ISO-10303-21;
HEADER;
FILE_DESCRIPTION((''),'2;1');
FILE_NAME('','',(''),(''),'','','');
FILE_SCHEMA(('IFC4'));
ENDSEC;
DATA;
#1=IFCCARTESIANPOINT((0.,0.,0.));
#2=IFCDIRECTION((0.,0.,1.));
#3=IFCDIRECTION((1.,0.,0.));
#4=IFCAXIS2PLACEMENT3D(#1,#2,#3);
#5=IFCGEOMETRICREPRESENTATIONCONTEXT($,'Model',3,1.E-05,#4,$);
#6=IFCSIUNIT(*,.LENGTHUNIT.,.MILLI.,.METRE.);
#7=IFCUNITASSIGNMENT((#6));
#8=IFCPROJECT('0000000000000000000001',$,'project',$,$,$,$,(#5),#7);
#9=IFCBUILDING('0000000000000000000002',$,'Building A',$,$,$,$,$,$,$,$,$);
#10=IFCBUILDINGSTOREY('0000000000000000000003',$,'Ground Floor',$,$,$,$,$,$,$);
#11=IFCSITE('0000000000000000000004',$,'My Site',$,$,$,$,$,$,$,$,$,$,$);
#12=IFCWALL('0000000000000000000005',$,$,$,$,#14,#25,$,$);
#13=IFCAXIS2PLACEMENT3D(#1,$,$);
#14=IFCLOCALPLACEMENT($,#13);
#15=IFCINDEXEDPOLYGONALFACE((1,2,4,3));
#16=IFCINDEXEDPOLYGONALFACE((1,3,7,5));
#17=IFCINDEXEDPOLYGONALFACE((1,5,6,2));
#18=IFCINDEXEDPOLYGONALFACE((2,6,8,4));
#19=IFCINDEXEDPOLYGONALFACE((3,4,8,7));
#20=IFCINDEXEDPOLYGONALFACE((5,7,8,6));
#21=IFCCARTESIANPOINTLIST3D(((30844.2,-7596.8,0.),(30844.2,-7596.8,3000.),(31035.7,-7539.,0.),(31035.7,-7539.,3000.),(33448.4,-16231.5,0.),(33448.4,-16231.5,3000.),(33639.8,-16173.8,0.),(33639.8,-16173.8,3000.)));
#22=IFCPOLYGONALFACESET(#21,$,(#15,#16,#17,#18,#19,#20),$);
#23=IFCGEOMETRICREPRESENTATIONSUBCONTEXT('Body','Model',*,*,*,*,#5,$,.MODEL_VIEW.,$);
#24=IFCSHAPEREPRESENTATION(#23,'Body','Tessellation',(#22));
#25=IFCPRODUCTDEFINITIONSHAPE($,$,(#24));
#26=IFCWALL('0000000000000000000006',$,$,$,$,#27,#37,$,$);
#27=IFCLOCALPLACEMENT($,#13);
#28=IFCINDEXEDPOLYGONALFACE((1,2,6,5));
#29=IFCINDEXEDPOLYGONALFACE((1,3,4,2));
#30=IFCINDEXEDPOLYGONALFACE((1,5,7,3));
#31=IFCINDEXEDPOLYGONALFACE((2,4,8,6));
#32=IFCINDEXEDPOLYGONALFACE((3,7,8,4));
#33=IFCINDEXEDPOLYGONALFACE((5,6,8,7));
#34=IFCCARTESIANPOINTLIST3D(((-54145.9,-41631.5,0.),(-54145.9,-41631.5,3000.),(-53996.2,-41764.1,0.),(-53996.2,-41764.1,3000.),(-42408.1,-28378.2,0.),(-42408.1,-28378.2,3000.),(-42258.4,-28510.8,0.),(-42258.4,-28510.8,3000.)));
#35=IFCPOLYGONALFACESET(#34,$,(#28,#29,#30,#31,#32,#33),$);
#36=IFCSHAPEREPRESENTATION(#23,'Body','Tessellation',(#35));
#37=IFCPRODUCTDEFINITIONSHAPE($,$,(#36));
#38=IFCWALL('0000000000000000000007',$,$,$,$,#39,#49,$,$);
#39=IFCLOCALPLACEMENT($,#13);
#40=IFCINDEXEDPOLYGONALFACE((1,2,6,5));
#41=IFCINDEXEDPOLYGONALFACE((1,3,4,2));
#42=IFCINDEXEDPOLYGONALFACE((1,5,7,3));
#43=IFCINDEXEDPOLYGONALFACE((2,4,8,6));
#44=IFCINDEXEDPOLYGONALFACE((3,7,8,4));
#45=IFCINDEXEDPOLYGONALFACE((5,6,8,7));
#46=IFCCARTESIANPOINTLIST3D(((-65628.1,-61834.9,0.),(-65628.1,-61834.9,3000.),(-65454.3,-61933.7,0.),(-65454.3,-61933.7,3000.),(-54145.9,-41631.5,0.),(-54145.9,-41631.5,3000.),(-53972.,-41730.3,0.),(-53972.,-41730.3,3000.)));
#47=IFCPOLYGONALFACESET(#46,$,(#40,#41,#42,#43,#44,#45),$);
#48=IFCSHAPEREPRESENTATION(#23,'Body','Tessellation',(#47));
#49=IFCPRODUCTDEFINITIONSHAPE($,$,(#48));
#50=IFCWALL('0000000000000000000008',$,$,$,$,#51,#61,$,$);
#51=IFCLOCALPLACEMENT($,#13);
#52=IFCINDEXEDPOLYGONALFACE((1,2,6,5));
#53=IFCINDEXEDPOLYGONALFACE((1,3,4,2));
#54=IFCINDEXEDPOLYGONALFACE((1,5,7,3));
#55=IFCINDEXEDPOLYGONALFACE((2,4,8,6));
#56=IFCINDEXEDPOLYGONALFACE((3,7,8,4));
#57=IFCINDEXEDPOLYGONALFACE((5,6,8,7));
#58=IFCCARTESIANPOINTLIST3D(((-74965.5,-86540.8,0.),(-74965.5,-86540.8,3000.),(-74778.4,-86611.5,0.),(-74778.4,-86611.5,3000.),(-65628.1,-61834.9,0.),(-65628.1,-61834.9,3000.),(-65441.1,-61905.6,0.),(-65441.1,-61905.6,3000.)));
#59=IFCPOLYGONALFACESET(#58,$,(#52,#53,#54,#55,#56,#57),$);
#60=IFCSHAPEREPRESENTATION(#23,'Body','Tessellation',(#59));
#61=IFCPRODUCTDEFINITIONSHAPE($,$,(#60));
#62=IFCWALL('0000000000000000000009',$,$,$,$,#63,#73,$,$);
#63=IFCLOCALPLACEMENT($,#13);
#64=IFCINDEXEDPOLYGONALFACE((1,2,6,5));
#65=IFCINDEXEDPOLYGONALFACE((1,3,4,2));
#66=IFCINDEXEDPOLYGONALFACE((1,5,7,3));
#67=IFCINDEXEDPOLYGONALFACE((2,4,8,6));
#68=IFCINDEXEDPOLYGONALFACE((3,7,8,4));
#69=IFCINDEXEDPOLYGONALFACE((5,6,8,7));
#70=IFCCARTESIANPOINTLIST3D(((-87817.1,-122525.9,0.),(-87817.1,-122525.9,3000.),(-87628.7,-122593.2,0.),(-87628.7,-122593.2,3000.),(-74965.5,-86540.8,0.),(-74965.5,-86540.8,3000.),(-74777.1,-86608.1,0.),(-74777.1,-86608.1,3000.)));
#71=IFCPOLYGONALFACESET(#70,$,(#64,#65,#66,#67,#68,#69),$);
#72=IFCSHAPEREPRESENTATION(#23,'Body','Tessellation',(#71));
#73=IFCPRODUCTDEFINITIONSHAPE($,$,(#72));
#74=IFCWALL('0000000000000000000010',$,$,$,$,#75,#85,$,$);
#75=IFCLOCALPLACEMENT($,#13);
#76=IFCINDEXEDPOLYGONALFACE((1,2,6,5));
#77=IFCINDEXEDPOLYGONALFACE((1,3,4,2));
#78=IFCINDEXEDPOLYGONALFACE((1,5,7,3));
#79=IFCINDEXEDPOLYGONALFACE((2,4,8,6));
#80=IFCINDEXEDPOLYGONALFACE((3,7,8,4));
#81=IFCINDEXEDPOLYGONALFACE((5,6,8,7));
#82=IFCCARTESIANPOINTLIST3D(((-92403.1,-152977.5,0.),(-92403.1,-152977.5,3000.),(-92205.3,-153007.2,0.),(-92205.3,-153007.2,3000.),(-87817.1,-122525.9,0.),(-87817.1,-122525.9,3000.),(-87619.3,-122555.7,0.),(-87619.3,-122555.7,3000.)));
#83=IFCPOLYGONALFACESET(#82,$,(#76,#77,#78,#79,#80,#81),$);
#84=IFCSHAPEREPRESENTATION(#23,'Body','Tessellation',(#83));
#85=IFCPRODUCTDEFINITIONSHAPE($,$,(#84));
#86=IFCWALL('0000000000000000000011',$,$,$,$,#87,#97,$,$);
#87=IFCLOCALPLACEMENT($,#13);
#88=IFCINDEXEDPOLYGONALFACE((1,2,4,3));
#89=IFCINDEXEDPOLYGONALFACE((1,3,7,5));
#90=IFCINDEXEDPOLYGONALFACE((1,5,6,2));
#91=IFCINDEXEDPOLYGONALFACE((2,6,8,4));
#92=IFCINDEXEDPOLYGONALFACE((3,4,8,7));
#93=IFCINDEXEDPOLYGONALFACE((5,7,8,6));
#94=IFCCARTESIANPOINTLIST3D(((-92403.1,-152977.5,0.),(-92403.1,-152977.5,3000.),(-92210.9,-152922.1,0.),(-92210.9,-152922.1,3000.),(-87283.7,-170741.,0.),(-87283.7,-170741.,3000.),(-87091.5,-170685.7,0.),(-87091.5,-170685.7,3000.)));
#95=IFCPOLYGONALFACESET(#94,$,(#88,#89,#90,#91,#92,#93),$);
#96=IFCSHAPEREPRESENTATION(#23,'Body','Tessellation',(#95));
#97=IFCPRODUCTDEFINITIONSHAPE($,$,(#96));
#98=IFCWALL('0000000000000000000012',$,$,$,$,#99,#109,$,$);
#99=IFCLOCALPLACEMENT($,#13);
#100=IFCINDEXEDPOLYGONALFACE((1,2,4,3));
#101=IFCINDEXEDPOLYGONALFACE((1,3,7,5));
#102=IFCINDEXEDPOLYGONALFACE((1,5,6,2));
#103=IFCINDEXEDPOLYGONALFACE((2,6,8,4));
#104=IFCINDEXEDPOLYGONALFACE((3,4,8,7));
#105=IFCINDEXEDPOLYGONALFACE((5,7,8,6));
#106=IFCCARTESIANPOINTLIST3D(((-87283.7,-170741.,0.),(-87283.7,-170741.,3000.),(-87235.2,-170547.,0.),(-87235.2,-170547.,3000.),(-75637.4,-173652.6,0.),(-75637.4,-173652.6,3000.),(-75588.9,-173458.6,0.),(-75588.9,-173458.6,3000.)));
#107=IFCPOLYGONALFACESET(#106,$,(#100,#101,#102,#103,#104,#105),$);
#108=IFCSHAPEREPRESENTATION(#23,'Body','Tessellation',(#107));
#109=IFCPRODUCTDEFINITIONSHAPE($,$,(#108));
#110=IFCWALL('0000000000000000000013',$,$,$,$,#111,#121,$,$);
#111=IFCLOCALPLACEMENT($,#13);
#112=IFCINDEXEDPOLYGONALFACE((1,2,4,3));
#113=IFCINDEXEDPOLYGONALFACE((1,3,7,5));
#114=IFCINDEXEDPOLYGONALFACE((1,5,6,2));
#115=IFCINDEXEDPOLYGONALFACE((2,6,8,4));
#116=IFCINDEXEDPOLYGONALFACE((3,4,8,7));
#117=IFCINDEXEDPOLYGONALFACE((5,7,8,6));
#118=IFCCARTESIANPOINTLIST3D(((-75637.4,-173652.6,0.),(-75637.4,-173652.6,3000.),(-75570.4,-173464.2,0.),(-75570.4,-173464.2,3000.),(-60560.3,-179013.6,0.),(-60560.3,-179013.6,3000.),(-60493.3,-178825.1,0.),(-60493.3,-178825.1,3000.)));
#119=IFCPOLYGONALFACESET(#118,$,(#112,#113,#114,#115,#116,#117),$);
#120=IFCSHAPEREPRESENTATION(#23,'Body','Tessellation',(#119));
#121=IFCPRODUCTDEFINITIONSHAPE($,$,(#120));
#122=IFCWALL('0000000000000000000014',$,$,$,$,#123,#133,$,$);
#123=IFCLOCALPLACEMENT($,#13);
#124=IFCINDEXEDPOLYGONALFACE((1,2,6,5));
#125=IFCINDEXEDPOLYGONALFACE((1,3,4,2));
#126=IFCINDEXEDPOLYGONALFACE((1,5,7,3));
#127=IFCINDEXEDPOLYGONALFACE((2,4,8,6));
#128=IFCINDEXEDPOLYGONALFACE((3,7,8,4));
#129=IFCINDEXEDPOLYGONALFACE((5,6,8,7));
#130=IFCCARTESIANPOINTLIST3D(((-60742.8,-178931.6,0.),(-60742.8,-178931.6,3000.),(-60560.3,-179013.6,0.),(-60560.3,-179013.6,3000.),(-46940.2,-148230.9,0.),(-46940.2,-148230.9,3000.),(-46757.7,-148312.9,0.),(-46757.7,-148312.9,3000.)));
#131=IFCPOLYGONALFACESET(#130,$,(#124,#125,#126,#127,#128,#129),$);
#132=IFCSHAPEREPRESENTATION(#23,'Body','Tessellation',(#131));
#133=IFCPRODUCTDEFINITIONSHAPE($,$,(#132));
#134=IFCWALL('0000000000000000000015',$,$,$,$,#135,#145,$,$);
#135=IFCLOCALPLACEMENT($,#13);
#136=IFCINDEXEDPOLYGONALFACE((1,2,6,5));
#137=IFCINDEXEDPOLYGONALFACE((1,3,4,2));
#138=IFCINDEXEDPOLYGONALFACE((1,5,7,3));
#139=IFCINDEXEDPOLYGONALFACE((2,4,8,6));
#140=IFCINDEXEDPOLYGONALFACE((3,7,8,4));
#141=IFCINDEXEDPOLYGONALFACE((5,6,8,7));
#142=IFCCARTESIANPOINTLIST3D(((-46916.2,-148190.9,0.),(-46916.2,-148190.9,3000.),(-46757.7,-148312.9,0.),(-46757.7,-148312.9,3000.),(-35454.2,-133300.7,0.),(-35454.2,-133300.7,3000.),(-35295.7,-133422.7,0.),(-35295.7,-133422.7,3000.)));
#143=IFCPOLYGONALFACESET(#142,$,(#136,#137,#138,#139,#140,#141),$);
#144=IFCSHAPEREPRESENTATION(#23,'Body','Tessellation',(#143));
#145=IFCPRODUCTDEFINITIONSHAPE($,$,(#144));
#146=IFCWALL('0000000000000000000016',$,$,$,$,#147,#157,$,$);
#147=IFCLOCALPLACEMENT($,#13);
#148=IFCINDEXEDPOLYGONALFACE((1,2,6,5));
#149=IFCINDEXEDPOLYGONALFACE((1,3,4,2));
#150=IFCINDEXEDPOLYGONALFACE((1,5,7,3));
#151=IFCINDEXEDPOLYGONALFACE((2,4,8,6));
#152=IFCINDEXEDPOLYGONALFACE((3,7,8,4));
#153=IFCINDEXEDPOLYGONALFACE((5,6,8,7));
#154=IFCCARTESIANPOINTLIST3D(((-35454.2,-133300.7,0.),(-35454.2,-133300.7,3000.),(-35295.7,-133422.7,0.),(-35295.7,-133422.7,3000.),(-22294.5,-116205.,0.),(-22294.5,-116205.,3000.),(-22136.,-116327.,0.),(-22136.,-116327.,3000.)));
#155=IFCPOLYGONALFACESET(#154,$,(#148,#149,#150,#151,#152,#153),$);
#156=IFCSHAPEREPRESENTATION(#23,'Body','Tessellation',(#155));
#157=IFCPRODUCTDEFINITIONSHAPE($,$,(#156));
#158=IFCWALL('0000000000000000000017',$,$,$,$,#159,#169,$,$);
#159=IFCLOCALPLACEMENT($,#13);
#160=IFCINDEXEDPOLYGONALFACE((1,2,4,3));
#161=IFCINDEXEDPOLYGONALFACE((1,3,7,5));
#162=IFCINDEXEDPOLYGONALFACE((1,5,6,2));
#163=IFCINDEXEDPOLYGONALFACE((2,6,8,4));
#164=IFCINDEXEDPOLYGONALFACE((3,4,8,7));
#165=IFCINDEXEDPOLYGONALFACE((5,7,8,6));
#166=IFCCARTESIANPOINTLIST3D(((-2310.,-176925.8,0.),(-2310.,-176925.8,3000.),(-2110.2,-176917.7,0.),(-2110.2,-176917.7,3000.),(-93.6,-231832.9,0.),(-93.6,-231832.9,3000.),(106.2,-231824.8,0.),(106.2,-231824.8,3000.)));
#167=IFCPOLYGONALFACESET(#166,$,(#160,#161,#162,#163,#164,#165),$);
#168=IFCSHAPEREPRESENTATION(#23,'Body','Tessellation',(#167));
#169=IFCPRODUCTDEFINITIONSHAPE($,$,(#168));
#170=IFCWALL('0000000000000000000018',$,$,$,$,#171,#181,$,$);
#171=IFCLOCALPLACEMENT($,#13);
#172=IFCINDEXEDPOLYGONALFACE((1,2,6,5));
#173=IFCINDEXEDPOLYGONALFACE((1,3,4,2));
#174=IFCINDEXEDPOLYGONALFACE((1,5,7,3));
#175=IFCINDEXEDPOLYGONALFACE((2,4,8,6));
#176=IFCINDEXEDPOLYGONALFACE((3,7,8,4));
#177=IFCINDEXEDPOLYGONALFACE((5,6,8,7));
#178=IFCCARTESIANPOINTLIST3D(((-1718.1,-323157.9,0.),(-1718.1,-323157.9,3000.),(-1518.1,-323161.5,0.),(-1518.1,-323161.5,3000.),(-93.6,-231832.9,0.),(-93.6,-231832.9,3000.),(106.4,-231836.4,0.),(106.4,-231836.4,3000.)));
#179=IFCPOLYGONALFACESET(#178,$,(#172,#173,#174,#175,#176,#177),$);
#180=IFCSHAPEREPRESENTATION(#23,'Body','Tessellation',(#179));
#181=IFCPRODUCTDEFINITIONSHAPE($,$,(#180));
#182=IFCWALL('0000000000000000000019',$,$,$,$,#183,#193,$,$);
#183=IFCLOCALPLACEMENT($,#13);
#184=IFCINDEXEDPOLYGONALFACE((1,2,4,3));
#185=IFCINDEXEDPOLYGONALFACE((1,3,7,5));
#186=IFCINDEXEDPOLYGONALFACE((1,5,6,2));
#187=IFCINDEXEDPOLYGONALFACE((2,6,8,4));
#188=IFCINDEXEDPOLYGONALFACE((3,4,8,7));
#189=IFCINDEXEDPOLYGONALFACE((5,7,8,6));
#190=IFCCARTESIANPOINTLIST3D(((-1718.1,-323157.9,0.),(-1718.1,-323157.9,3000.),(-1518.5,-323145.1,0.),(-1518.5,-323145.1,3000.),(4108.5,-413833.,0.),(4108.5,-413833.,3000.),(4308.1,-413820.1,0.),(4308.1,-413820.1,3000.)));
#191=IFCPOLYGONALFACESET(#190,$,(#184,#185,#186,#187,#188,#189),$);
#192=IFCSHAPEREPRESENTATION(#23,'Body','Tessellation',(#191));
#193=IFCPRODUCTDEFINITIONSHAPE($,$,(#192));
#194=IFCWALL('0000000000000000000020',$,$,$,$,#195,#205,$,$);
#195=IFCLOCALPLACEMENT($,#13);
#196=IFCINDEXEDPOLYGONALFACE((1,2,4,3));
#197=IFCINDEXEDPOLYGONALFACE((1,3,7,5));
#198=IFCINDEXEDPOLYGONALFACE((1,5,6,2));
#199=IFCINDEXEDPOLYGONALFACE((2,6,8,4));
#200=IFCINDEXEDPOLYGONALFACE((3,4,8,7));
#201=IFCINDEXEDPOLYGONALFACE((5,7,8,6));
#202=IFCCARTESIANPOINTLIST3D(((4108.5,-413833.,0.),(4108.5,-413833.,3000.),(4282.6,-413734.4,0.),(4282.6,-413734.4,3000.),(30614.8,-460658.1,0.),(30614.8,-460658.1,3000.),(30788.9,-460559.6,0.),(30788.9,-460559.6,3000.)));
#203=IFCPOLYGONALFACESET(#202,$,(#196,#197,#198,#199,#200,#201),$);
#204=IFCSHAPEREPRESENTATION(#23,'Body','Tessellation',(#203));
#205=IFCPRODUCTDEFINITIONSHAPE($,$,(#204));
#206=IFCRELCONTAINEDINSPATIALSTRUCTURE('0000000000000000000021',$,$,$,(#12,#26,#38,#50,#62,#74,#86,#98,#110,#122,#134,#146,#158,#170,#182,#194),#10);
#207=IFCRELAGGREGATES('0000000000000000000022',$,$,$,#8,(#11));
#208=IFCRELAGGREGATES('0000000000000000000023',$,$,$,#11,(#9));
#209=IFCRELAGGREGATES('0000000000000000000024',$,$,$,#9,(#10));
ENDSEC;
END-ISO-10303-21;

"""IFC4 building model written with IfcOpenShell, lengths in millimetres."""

from ifc_helpers import new_model, si_unit, frame, origin_with_axes, place, context, subcontext, project, spatial, indexed_curve, outline, extrude, element, save


model = new_model("IFC4")

# Units and contexts
model_context = context("Model", 3, precision=1e-05, world=origin_with_axes())
body_context = subcontext(model_context, "Body", "Model", "MODEL_VIEW")
ifc_project = project(units=[si_unit("LENGTHUNIT", "METRE", prefix="MILLI")], contexts=[model_context])

# Site, building, storey
site = spatial("IfcSite", under=ifc_project, Name="My Site")
building = spatial("IfcBuilding", under=site, Name="Building A")
storey = spatial("IfcBuildingStorey", under=building, Name="Ground Floor")

# Walls
wall_1_placement = place(None, frame((33639.8, -16173.8, 0.0), z_axis=(0.0, 0.0, 1.0), x_axis=(-0.288745, 0.957406, 0.0)))
element("IfcWall", 1, at=wall_1_placement, inside=storey, context=body_context, shape_type="SweptSolid", body=[
    extrude(outline(indexed_curve([(0.0, 0.0), (0.0, 200.0), (9018.9, 200.0), (9018.9, 0.0), (0.0, 0.0)], self_intersect=False)), origin_with_axes(), (0.0, 0.0, 1.0), 3000.0),
])
wall_2_placement = place(None, frame((-42408.1, -28378.2, 0.0), z_axis=(0.0, 0.0, 1.0), x_axis=(-0.663009, -0.748612, 0.0)))
element("IfcWall", 2, at=wall_2_placement, inside=storey, context=body_context, shape_type="SweptSolid", body=[
    extrude(outline(indexed_curve([(0.0, 0.0), (0.0, 200.0), (17703.9, 200.0), (17703.9, 0.0), (0.0, 0.0)], self_intersect=False)), origin_with_axes(), (0.0, 0.0, 1.0), 3000.0),
])
wall_3_placement = place(None, frame((-54145.9, -41631.5, 0.0), z_axis=(0.0, 0.0, 1.0), x_axis=(-0.494108, -0.8694, 0.0)))
element("IfcWall", 3, at=wall_3_placement, inside=storey, context=body_context, shape_type="SweptSolid", body=[
    extrude(outline(indexed_curve([(0.0, 0.0), (0.0, 200.0), (23238.3, 200.0), (23238.3, 0.0), (0.0, 0.0)], self_intersect=False)), origin_with_axes(), (0.0, 0.0, 1.0), 3000.0),
])
wall_4_placement = place(None, frame((-65628.1, -61834.9, 0.0), z_axis=(0.0, 0.0, 1.0), x_axis=(-0.353532, -0.935422, 0.0)))
element("IfcWall", 4, at=wall_4_placement, inside=storey, context=body_context, shape_type="SweptSolid", body=[
    extrude(outline(indexed_curve([(0.0, 0.0), (0.0, 200.0), (26411.5, 200.0), (26411.5, 0.0), (0.0, 0.0)], self_intersect=False)), origin_with_axes(), (0.0, 0.0, 1.0), 3000.0),
])
wall_5_placement = place(None, frame((-74965.5, -86540.8, 0.0), z_axis=(0.0, 0.0, 1.0), x_axis=(-0.336331, -0.941744, 0.0)))
element("IfcWall", 5, at=wall_5_placement, inside=storey, context=body_context, shape_type="SweptSolid", body=[
    extrude(outline(indexed_curve([(0.0, 0.0), (0.0, 200.0), (38211.2, 200.0), (38211.2, 0.0), (0.0, 0.0)], self_intersect=False)), origin_with_axes(), (0.0, 0.0, 1.0), 3000.0),
])
wall_6_placement = place(None, frame((-87817.1, -122525.9, 0.0), z_axis=(0.0, 0.0, 1.0), x_axis=(-0.148922, -0.988849, 0.0)))
element("IfcWall", 6, at=wall_6_placement, inside=storey, context=body_context, shape_type="SweptSolid", body=[
    extrude(outline(indexed_curve([(0.0, 0.0), (0.0, 200.0), (30794.9, 200.0), (30794.9, 0.0), (0.0, 0.0)], self_intersect=False)), origin_with_axes(), (0.0, 0.0, 1.0), 3000.0),
])
wall_7_placement = place(None, frame((-92403.1, -152977.5, 0.0), z_axis=(0.0, 0.0, 1.0), x_axis=(0.276927, -0.960891, 0.0)))
element("IfcWall", 7, at=wall_7_placement, inside=storey, context=body_context, shape_type="SweptSolid", body=[
    extrude(outline(indexed_curve([(0.0, 0.0), (0.0, 200.0), (18486.6, 200.0), (18486.6, 0.0), (0.0, 0.0)], self_intersect=False)), origin_with_axes(), (0.0, 0.0, 1.0), 3000.0),
])
wall_8_placement = place(None, frame((-87283.7, -170741.0, 0.0), z_axis=(0.0, 0.0, 1.0), x_axis=(0.970143, -0.242536, 0.0)))
element("IfcWall", 8, at=wall_8_placement, inside=storey, context=body_context, shape_type="SweptSolid", body=[
    extrude(outline(indexed_curve([(0.0, 0.0), (0.0, 200.0), (12004.7, 200.0), (12004.7, 0.0), (0.0, 0.0)], self_intersect=False)), origin_with_axes(), (0.0, 0.0, 1.0), 3000.0),
])
wall_9_placement = place(None, frame((-75637.4, -173652.6, 0.0), z_axis=(0.0, 0.0, 1.0), x_axis=(0.94221, -0.335023, 0.0)))
element("IfcWall", 9, at=wall_9_placement, inside=storey, context=body_context, shape_type="SweptSolid", body=[
    extrude(outline(indexed_curve([(0.0, 0.0), (0.0, 200.0), (16001.8, 200.0), (16001.8, 0.0), (0.0, 0.0)], self_intersect=False)), origin_with_axes(), (0.0, 0.0, 1.0), 3000.0),
])
wall_10_placement = place(None, frame((-60560.3, -179013.6, 0.0), z_axis=(0.0, 0.0, 1.0), x_axis=(0.410051, 0.912063, 0.0)))
element("IfcWall", 10, at=wall_10_placement, inside=storey, context=body_context, shape_type="SweptSolid", body=[
    extrude(outline(indexed_curve([(0.0, 0.0), (0.0, 200.0), (33660.7, 200.0), (33660.7, 0.0), (0.0, 0.0)], self_intersect=False)), origin_with_axes(), (0.0, 0.0, 1.0), 3000.0),
])
wall_11_placement = place(None, frame((-46757.7, -148312.9, 0.0), z_axis=(0.0, 0.0, 1.0), x_axis=(0.609978, 0.792418, 0.0)))
element("IfcWall", 11, at=wall_11_placement, inside=storey, context=body_context, shape_type="SweptSolid", body=[
    extrude(outline(indexed_curve([(0.0, 0.0), (0.0, 200.0), (18790.9, 200.0), (18790.9, 0.0), (0.0, 0.0)], self_intersect=False)), origin_with_axes(), (0.0, 0.0, 1.0), 3000.0),
])
wall_12_placement = place(None, frame((-35295.7, -133422.7, 0.0), z_axis=(0.0, 0.0, 1.0), x_axis=(0.609978, 0.792418, 0.0)))
element("IfcWall", 12, at=wall_12_placement, inside=storey, context=body_context, shape_type="SweptSolid", body=[
    extrude(outline(indexed_curve([(0.0, 0.0), (0.0, 200.0), (21574.1, 200.0), (21574.1, 0.0), (0.0, 0.0)], self_intersect=False)), origin_with_axes(), (0.0, 0.0, 1.0), 3000.0),
])
wall_13_placement = place(None, frame((-2310.0, -176925.8, 0.0), z_axis=(0.0, 0.0, 1.0), x_axis=(0.040334, -0.999186, 0.0)))
element("IfcWall", 13, at=wall_13_placement, inside=storey, context=body_context, shape_type="SweptSolid", body=[
    extrude(outline(indexed_curve([(0.0, 0.0), (0.0, 200.0), (54951.8, 200.0), (54951.8, 0.0), (0.0, 0.0)], self_intersect=False)), origin_with_axes(), (0.0, 0.0, 1.0), 3000.0),
])
wall_14_placement = place(None, frame((-93.6, -231832.9, 0.0), z_axis=(0.0, 0.0, 1.0), x_axis=(-0.017785, -0.999842, 0.0)))
element("IfcWall", 14, at=wall_14_placement, inside=storey, context=body_context, shape_type="SweptSolid", body=[
    extrude(outline(indexed_curve([(0.0, 0.0), (0.0, 200.0), (91339.5, 200.0), (91339.5, 0.0), (0.0, 0.0)], self_intersect=False)), origin_with_axes(), (0.0, 0.0, 1.0), 3000.0),
])
wall_15_placement = place(None, frame((-1718.1, -323157.9, 0.0), z_axis=(0.0, 0.0, 1.0), x_axis=(0.064126, -0.997942, 0.0)))
element("IfcWall", 15, at=wall_15_placement, inside=storey, context=body_context, shape_type="SweptSolid", body=[
    extrude(outline(indexed_curve([(0.0, 0.0), (0.0, 200.0), (90862.0, 200.0), (90862.0, 0.0), (0.0, 0.0)], self_intersect=False)), origin_with_axes(), (0.0, 0.0, 1.0), 3000.0),
])
wall_16_placement = place(None, frame((4108.5, -413833.0, 0.0), z_axis=(0.0, 0.0, 1.0), x_axis=(0.49262, -0.870244, 0.0)))
element("IfcWall", 16, at=wall_16_placement, inside=storey, context=body_context, shape_type="SweptSolid", body=[
    extrude(outline(indexed_curve([(0.0, 0.0), (0.0, 200.0), (53806.9, 200.0), (53806.9, 0.0), (0.0, 0.0)], self_intersect=False)), origin_with_axes(), (0.0, 0.0, 1.0), 3000.0),
])

save(model, "model.ifc")
